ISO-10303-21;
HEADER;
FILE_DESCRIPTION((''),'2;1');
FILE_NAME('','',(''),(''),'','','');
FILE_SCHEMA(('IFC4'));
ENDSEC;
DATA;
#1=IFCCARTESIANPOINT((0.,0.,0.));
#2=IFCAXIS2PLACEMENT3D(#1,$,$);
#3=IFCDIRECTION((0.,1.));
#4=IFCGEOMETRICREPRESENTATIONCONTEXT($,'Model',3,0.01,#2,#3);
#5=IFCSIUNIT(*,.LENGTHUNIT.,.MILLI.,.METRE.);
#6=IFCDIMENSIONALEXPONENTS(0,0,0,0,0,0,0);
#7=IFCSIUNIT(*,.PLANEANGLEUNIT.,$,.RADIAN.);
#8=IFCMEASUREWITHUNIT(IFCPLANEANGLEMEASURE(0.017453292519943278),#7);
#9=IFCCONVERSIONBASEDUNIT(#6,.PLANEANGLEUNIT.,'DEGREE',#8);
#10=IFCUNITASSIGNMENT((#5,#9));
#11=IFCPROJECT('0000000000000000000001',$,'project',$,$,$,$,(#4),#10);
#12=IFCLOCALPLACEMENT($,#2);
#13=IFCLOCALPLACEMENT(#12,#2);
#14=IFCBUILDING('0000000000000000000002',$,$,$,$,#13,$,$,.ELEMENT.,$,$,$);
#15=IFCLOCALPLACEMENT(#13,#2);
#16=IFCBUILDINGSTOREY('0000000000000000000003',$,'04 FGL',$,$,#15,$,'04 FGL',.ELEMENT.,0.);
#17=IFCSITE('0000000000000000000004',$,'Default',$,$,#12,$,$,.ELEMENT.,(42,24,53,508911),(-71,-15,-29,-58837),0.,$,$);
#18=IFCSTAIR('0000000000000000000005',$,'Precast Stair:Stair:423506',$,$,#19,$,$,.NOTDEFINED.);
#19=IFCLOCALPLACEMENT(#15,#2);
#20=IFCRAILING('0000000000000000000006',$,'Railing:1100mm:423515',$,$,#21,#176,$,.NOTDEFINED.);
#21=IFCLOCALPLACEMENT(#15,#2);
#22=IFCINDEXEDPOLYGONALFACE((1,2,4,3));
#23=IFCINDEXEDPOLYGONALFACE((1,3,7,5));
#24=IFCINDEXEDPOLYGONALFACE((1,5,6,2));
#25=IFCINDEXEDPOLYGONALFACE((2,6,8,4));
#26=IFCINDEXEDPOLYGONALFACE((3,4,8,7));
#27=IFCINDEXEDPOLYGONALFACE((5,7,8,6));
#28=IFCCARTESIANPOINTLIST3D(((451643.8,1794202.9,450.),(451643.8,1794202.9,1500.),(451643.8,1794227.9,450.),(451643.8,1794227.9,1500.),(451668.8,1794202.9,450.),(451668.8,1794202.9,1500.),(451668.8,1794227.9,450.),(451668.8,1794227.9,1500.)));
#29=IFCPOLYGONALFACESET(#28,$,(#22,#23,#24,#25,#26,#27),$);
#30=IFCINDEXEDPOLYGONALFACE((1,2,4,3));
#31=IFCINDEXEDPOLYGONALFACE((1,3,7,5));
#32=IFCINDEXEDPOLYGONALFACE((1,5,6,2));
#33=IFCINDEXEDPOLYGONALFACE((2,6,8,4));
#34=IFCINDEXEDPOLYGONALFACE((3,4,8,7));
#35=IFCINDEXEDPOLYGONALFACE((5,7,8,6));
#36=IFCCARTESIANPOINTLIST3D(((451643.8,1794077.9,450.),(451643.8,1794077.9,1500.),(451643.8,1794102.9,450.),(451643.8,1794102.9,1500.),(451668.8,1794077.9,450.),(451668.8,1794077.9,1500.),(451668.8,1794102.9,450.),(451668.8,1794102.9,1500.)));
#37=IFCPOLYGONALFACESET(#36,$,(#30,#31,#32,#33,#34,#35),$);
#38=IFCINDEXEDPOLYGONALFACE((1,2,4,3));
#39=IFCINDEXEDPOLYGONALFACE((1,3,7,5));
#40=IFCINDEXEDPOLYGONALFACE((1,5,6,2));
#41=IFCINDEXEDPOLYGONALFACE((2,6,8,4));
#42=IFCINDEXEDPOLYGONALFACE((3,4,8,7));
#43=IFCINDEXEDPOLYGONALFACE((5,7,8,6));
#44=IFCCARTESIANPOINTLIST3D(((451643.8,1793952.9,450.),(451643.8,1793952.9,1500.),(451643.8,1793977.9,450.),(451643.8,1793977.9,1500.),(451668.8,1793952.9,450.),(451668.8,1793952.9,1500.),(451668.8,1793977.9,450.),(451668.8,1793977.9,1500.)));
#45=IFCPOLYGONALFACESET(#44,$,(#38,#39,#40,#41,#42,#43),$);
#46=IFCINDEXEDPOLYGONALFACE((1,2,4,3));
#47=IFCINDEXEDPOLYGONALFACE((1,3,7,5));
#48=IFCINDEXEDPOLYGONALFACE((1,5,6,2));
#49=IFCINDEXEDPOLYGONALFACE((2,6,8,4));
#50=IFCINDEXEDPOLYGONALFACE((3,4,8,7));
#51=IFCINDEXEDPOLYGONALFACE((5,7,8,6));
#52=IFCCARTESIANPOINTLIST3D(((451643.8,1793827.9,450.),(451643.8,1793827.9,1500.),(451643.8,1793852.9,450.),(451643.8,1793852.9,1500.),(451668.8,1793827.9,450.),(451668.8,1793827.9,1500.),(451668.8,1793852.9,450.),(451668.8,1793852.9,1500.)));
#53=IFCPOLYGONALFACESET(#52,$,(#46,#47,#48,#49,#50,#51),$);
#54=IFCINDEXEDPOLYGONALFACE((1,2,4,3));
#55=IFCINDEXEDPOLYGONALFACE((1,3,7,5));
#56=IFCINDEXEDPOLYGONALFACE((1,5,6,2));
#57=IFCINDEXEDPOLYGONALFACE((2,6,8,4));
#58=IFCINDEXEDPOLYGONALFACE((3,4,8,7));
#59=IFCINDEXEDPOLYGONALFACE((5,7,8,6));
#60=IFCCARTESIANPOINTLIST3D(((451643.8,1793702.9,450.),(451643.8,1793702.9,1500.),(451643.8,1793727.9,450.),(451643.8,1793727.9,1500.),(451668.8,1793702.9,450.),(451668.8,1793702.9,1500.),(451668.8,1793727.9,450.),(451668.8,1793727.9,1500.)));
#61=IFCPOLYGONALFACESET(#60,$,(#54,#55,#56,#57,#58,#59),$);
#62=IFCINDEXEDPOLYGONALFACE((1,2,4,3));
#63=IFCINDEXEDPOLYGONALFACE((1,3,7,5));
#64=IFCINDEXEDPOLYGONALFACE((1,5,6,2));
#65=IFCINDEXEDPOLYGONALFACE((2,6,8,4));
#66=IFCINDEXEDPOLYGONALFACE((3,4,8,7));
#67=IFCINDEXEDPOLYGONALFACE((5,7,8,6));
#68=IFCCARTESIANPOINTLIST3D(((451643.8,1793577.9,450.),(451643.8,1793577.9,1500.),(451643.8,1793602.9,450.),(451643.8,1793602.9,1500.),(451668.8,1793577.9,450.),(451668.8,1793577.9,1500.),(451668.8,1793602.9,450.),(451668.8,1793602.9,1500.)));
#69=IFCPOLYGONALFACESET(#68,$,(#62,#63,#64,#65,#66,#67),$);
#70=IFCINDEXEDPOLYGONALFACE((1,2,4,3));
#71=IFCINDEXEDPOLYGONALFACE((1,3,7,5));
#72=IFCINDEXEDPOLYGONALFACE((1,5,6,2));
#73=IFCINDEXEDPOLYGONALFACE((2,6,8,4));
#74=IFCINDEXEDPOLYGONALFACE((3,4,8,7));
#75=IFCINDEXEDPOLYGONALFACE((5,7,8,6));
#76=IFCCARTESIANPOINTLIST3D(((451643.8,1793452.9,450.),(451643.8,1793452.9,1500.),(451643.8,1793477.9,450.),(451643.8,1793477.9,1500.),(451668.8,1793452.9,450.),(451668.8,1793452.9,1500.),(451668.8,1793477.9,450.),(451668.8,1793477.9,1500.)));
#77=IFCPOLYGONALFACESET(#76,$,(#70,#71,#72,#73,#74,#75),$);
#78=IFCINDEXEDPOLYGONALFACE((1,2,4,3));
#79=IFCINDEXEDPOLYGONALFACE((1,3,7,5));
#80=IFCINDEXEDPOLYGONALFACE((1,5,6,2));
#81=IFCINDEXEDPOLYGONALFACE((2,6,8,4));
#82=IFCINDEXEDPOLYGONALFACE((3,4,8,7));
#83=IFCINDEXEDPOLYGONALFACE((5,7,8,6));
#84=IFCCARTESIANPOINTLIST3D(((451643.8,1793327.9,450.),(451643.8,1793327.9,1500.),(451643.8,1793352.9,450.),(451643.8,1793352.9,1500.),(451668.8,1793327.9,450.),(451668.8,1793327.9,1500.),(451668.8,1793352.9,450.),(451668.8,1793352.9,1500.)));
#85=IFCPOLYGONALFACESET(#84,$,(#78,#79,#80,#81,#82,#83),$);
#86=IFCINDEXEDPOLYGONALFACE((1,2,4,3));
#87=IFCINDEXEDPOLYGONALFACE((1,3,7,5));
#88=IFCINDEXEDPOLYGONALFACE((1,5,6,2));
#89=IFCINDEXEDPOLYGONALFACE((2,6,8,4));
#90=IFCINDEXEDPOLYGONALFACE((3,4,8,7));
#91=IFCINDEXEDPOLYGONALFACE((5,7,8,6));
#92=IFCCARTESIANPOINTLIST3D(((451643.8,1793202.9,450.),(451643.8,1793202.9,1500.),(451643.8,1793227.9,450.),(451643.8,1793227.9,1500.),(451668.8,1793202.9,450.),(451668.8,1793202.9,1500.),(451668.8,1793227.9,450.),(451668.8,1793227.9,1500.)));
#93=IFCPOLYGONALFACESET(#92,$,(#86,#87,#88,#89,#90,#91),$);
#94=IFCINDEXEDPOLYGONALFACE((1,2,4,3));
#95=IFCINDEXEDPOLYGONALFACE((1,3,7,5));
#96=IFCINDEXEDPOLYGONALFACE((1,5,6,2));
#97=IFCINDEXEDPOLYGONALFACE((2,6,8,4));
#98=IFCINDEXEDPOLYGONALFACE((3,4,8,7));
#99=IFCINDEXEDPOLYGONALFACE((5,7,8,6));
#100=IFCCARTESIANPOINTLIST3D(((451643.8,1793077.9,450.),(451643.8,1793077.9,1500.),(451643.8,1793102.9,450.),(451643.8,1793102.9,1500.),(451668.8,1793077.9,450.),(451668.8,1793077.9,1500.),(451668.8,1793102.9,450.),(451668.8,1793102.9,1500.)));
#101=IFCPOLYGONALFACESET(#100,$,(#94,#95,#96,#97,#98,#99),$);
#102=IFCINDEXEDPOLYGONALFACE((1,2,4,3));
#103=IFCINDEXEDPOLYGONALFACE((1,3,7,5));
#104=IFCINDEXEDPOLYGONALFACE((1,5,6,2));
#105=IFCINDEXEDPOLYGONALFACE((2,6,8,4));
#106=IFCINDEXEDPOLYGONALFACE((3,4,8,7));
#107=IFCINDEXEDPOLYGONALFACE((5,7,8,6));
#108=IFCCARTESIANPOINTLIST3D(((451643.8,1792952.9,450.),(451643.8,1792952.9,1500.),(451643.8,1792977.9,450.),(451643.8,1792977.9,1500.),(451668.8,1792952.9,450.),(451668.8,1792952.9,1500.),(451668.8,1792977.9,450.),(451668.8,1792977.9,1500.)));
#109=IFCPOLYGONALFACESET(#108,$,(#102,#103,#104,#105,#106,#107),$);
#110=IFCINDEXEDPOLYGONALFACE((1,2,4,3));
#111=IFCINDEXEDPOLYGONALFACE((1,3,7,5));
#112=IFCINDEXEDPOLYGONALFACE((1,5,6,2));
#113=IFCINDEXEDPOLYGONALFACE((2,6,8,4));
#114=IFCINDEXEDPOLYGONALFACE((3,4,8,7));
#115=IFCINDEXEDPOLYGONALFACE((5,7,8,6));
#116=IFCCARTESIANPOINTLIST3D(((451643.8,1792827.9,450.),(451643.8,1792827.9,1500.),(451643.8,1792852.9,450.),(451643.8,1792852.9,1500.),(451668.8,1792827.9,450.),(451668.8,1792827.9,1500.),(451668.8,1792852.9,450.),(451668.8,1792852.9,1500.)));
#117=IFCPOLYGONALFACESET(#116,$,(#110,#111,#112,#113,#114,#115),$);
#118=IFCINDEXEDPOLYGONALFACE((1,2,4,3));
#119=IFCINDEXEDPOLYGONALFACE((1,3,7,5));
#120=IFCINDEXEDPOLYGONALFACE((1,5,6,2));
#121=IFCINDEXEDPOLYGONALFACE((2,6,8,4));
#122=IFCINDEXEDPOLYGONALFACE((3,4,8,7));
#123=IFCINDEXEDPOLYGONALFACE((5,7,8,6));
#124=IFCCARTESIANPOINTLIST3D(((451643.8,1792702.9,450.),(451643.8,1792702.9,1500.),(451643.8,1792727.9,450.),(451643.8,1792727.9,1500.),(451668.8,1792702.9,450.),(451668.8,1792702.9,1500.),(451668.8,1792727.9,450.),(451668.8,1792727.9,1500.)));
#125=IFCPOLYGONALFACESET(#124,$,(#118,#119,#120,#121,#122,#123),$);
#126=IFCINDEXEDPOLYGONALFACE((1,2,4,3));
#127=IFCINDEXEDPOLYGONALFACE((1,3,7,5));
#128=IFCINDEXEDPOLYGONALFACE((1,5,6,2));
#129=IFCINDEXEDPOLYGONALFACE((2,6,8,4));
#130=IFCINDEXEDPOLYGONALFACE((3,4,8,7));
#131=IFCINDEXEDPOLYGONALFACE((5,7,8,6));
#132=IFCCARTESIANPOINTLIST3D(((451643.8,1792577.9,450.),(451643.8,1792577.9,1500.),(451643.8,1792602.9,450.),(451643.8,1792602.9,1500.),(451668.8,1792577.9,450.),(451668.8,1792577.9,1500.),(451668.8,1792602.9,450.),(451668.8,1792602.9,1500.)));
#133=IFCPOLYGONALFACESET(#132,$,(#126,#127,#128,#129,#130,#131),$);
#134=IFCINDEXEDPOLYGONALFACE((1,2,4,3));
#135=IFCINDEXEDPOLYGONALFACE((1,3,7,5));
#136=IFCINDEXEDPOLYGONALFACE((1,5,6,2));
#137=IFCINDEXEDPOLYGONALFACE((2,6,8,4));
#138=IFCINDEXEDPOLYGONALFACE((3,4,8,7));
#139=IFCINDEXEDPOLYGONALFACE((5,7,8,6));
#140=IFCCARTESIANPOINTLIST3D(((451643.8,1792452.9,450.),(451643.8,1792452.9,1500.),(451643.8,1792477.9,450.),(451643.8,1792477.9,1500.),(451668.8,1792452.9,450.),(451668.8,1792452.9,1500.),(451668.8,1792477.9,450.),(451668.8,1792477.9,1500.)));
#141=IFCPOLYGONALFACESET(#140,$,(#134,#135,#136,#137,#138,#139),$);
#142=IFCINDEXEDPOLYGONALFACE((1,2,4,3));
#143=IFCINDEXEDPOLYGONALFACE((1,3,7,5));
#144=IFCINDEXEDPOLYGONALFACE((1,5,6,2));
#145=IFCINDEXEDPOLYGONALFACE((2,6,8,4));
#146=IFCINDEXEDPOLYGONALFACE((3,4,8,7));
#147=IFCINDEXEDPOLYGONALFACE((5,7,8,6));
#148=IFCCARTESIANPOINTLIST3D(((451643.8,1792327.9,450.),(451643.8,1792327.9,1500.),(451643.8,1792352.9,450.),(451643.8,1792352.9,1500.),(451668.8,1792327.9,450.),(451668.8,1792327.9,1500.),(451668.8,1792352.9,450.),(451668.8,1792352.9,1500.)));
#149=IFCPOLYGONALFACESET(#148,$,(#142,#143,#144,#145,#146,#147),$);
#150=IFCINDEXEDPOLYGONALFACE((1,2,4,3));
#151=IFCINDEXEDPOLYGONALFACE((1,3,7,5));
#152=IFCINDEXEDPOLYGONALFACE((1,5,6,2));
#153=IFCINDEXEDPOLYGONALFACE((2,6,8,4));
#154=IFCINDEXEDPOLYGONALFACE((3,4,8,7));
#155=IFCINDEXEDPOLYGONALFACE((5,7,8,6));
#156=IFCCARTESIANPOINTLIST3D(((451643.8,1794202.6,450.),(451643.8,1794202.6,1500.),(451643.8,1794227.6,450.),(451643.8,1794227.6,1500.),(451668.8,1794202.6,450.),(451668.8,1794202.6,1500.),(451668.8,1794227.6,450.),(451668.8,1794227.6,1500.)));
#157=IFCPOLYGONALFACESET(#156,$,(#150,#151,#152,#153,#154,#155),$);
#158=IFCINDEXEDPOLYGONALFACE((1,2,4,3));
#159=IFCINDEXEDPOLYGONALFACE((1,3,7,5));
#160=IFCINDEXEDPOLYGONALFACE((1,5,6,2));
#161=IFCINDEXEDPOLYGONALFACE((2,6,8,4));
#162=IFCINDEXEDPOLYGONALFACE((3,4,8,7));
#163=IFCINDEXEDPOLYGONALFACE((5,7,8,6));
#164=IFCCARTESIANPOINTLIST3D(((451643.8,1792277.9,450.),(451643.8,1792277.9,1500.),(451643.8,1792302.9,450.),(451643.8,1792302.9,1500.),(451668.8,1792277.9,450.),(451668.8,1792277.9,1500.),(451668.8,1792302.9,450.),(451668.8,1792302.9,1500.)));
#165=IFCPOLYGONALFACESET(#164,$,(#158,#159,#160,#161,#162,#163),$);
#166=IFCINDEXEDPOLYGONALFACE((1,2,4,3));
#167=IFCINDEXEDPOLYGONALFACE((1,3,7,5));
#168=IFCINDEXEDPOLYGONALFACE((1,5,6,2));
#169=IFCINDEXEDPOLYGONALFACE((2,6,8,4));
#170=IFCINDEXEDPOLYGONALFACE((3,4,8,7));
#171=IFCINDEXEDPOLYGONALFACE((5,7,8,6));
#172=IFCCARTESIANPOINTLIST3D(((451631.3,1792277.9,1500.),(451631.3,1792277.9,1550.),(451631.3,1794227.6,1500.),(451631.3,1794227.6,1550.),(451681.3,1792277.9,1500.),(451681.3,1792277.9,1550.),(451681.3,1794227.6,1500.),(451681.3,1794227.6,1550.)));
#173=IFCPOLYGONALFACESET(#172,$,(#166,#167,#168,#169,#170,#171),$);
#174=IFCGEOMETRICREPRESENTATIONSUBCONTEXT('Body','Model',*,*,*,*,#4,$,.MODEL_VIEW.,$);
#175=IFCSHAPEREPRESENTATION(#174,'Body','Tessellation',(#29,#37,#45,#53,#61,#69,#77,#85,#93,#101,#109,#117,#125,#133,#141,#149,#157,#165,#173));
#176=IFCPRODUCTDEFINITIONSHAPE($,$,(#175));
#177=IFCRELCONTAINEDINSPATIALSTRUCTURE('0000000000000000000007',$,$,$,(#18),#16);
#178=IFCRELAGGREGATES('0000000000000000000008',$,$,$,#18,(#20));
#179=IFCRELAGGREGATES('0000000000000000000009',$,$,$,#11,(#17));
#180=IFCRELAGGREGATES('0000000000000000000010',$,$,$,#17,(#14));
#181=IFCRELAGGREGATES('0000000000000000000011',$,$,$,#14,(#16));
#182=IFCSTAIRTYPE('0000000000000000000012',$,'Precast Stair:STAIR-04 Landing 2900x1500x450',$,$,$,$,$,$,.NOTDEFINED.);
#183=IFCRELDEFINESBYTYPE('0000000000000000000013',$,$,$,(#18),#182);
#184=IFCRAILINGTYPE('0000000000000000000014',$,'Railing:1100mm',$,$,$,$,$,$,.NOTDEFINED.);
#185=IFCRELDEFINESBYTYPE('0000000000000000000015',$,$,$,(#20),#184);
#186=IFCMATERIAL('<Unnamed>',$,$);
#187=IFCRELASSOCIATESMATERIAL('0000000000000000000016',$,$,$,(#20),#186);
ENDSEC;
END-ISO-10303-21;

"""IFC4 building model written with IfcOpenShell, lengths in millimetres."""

from ifc_helpers import new_model, entity, si_unit, converted_unit, direction, frame, origin, place, context, subcontext, project, spatial, indexed_curve, outline, extrude, material, type_object, element, aggregate, save


model = new_model("IFC4")

# Units and contexts
model_context = context("Model", 3, precision=0.01, world=origin(), true_north=direction((0.0, 1.0)))
body_context = subcontext(model_context, "Body", "Model", "MODEL_VIEW")
ifc_project = project(units=[si_unit("LENGTHUNIT", "METRE", prefix="MILLI"), converted_unit("PLANEANGLEUNIT", "DEGREE", entity("IfcPlaneAngleMeasure", 0.017453292519943278), si_unit("PLANEANGLEUNIT", "RADIAN"), dimensions=[0, 0, 0, 0, 0, 0, 0])], contexts=[model_context])

# Site, building, storey
site_placement = place(None, origin())
site = spatial("IfcSite", under=ifc_project, at=site_placement, Name="Default", CompositionType="ELEMENT", RefLatitude=(42, 24, 53, 508911), RefLongitude=(-71, -15, -29, -58837), RefElevation=0.0)
building_placement = place(site_placement, origin())
building = spatial("IfcBuilding", under=site, at=building_placement, CompositionType="ELEMENT")
storey_placement = place(building_placement, origin())
storey = spatial("IfcBuildingStorey", under=building, at=storey_placement, Name="04 FGL", LongName="04 FGL", CompositionType="ELEMENT", Elevation=0.0)

# Stair, railing
stair_type = type_object("IfcStairType", Name="Precast Stair:STAIR-04 Landing 2900x1500x450", PredefinedType="NOTDEFINED")
stair_placement = place(storey_placement, origin())
stair = element("IfcStair", 1, at=stair_placement, inside=storey, type_object=stair_type, Name="Precast Stair:Stair:423506", PredefinedType="NOTDEFINED")
ifc_material_1 = material(Name="<Unnamed>")
railing_type = type_object("IfcRailingType", Name="Railing:1100mm", PredefinedType="NOTDEFINED")
railing_1_placement = place(stair_placement, frame((0.0, 0.0, 450.0)))
railing_1 = element("IfcRailing", 2, at=railing_1_placement, type_object=railing_type, material=ifc_material_1, Name="Railing:1100mm:423515", PredefinedType="NOTDEFINED", context=body_context, shape_type="SweptSolid", body=[
    extrude(outline(indexed_curve([(-12.5, -12.5), (12.5, -12.5), (12.5, 12.5), (-12.5, 12.5), (-12.5, -12.5)], self_intersect=False)), frame((451656.3, 1794215.4, 0.0), z_axis=(0.0, 0.0, 1.0), x_axis=(0.0, 1.0, 0.0)), (0.0, 0.0, 1.0), 1050.0),
    extrude(outline(indexed_curve([(-12.5, -12.5), (12.5, -12.5), (12.5, 12.5), (-12.5, 12.5), (-12.5, -12.5)], self_intersect=False)), frame((451656.3, 1794090.4, 0.0), z_axis=(0.0, 0.0, 1.0), x_axis=(0.0, 1.0, 0.0)), (0.0, 0.0, 1.0), 1050.0),
    extrude(outline(indexed_curve([(-12.5, -12.5), (12.5, -12.5), (12.5, 12.5), (-12.5, 12.5), (-12.5, -12.5)], self_intersect=False)), frame((451656.3, 1793965.4, 0.0), z_axis=(0.0, 0.0, 1.0), x_axis=(0.0, 1.0, 0.0)), (0.0, 0.0, 1.0), 1050.0),
    extrude(outline(indexed_curve([(-12.5, -12.5), (12.5, -12.5), (12.5, 12.5), (-12.5, 12.5), (-12.5, -12.5)], self_intersect=False)), frame((451656.3, 1793840.4, 0.0), z_axis=(0.0, 0.0, 1.0), x_axis=(0.0, 1.0, 0.0)), (0.0, 0.0, 1.0), 1050.0),
    extrude(outline(indexed_curve([(-12.5, -12.5), (12.5, -12.5), (12.5, 12.5), (-12.5, 12.5), (-12.5, -12.5)], self_intersect=False)), frame((451656.3, 1793715.4, 0.0), z_axis=(0.0, 0.0, 1.0), x_axis=(0.0, 1.0, 0.0)), (0.0, 0.0, 1.0), 1050.0),
    extrude(outline(indexed_curve([(-12.5, -12.5), (12.5, -12.5), (12.5, 12.5), (-12.5, 12.5), (-12.5, -12.5)], self_intersect=False)), frame((451656.3, 1793590.4, 0.0), z_axis=(0.0, 0.0, 1.0), x_axis=(0.0, 1.0, 0.0)), (0.0, 0.0, 1.0), 1050.0),
    extrude(outline(indexed_curve([(-12.5, -12.5), (12.5, -12.5), (12.5, 12.5), (-12.5, 12.5), (-12.5, -12.5)], self_intersect=False)), frame((451656.3, 1793465.4, 0.0), z_axis=(0.0, 0.0, 1.0), x_axis=(0.0, 1.0, 0.0)), (0.0, 0.0, 1.0), 1050.0),
    extrude(outline(indexed_curve([(-12.5, -12.5), (12.5, -12.5), (12.5, 12.5), (-12.5, 12.5), (-12.5, -12.5)], self_intersect=False)), frame((451656.3, 1793340.4, 0.0), z_axis=(0.0, 0.0, 1.0), x_axis=(0.0, 1.0, 0.0)), (0.0, 0.0, 1.0), 1050.0),
    extrude(outline(indexed_curve([(-12.5, -12.5), (12.5, -12.5), (12.5, 12.5), (-12.5, 12.5), (-12.5, -12.5)], self_intersect=False)), frame((451656.3, 1793215.4, 0.0), z_axis=(0.0, 0.0, 1.0), x_axis=(0.0, 1.0, 0.0)), (0.0, 0.0, 1.0), 1050.0),
    extrude(outline(indexed_curve([(-12.5, -12.5), (12.5, -12.5), (12.5, 12.5), (-12.5, 12.5), (-12.5, -12.5)], self_intersect=False)), frame((451656.3, 1793090.4, 0.0), z_axis=(0.0, 0.0, 1.0), x_axis=(0.0, 1.0, 0.0)), (0.0, 0.0, 1.0), 1050.0),
    extrude(outline(indexed_curve([(-12.5, -12.5), (12.5, -12.5), (12.5, 12.5), (-12.5, 12.5), (-12.5, -12.5)], self_intersect=False)), frame((451656.3, 1792965.4, 0.0), z_axis=(0.0, 0.0, 1.0), x_axis=(0.0, 1.0, 0.0)), (0.0, 0.0, 1.0), 1050.0),
    extrude(outline(indexed_curve([(-12.5, -12.5), (12.5, -12.5), (12.5, 12.5), (-12.5, 12.5), (-12.5, -12.5)], self_intersect=False)), frame((451656.3, 1792840.4, 0.0), z_axis=(0.0, 0.0, 1.0), x_axis=(0.0, 1.0, 0.0)), (0.0, 0.0, 1.0), 1050.0),
    extrude(outline(indexed_curve([(-12.5, -12.5), (12.5, -12.5), (12.5, 12.5), (-12.5, 12.5), (-12.5, -12.5)], self_intersect=False)), frame((451656.3, 1792715.4, 0.0), z_axis=(0.0, 0.0, 1.0), x_axis=(0.0, 1.0, 0.0)), (0.0, 0.0, 1.0), 1050.0),
    extrude(outline(indexed_curve([(-12.5, -12.5), (12.5, -12.5), (12.5, 12.5), (-12.5, 12.5), (-12.5, -12.5)], self_intersect=False)), frame((451656.3, 1792590.4, 0.0), z_axis=(0.0, 0.0, 1.0), x_axis=(0.0, 1.0, 0.0)), (0.0, 0.0, 1.0), 1050.0),
    extrude(outline(indexed_curve([(-12.5, -12.5), (12.5, -12.5), (12.5, 12.5), (-12.5, 12.5), (-12.5, -12.5)], self_intersect=False)), frame((451656.3, 1792465.4, 0.0), z_axis=(0.0, 0.0, 1.0), x_axis=(0.0, 1.0, 0.0)), (0.0, 0.0, 1.0), 1050.0),
    extrude(outline(indexed_curve([(-12.5, -12.5), (12.5, -12.5), (12.5, 12.5), (-12.5, 12.5), (-12.5, -12.5)], self_intersect=False)), frame((451656.3, 1792340.4, 0.0), z_axis=(0.0, 0.0, 1.0), x_axis=(0.0, 1.0, 0.0)), (0.0, 0.0, 1.0), 1050.0),
    extrude(outline(indexed_curve([(-12.5, -12.5), (12.5, -12.5), (12.5, 12.5), (-12.5, 12.5), (-12.5, -12.5)], self_intersect=False)), frame((451656.3, 1794215.1, 0.0), z_axis=(0.0, 0.0, 1.0), x_axis=(0.0, 1.0, 0.0)), (0.0, 0.0, 1.0), 1050.0),
    extrude(outline(indexed_curve([(-12.5, -12.5), (12.5, -12.5), (12.5, 12.5), (-12.5, 12.5), (-12.5, -12.5)], self_intersect=False)), frame((451656.3, 1792290.4, 0.0), z_axis=(0.0, 0.0, 1.0), x_axis=(0.0, 1.0, 0.0)), (0.0, 0.0, 1.0), 1050.0),
    extrude(outline(indexed_curve([(-974.9, -25.0), (974.9, -25.0), (974.9, 25.0), (-974.9, 25.0), (-974.9, -25.0)], self_intersect=False)), frame((451656.3, 1793252.8, 1050.0), z_axis=(0.0, 0.0, 1.0), x_axis=(0.0, 1.0, 0.0)), (0.0, 0.0, 1.0), 50.0),
])
aggregate(stair, [railing_1])

save(model, "model.ifc")
